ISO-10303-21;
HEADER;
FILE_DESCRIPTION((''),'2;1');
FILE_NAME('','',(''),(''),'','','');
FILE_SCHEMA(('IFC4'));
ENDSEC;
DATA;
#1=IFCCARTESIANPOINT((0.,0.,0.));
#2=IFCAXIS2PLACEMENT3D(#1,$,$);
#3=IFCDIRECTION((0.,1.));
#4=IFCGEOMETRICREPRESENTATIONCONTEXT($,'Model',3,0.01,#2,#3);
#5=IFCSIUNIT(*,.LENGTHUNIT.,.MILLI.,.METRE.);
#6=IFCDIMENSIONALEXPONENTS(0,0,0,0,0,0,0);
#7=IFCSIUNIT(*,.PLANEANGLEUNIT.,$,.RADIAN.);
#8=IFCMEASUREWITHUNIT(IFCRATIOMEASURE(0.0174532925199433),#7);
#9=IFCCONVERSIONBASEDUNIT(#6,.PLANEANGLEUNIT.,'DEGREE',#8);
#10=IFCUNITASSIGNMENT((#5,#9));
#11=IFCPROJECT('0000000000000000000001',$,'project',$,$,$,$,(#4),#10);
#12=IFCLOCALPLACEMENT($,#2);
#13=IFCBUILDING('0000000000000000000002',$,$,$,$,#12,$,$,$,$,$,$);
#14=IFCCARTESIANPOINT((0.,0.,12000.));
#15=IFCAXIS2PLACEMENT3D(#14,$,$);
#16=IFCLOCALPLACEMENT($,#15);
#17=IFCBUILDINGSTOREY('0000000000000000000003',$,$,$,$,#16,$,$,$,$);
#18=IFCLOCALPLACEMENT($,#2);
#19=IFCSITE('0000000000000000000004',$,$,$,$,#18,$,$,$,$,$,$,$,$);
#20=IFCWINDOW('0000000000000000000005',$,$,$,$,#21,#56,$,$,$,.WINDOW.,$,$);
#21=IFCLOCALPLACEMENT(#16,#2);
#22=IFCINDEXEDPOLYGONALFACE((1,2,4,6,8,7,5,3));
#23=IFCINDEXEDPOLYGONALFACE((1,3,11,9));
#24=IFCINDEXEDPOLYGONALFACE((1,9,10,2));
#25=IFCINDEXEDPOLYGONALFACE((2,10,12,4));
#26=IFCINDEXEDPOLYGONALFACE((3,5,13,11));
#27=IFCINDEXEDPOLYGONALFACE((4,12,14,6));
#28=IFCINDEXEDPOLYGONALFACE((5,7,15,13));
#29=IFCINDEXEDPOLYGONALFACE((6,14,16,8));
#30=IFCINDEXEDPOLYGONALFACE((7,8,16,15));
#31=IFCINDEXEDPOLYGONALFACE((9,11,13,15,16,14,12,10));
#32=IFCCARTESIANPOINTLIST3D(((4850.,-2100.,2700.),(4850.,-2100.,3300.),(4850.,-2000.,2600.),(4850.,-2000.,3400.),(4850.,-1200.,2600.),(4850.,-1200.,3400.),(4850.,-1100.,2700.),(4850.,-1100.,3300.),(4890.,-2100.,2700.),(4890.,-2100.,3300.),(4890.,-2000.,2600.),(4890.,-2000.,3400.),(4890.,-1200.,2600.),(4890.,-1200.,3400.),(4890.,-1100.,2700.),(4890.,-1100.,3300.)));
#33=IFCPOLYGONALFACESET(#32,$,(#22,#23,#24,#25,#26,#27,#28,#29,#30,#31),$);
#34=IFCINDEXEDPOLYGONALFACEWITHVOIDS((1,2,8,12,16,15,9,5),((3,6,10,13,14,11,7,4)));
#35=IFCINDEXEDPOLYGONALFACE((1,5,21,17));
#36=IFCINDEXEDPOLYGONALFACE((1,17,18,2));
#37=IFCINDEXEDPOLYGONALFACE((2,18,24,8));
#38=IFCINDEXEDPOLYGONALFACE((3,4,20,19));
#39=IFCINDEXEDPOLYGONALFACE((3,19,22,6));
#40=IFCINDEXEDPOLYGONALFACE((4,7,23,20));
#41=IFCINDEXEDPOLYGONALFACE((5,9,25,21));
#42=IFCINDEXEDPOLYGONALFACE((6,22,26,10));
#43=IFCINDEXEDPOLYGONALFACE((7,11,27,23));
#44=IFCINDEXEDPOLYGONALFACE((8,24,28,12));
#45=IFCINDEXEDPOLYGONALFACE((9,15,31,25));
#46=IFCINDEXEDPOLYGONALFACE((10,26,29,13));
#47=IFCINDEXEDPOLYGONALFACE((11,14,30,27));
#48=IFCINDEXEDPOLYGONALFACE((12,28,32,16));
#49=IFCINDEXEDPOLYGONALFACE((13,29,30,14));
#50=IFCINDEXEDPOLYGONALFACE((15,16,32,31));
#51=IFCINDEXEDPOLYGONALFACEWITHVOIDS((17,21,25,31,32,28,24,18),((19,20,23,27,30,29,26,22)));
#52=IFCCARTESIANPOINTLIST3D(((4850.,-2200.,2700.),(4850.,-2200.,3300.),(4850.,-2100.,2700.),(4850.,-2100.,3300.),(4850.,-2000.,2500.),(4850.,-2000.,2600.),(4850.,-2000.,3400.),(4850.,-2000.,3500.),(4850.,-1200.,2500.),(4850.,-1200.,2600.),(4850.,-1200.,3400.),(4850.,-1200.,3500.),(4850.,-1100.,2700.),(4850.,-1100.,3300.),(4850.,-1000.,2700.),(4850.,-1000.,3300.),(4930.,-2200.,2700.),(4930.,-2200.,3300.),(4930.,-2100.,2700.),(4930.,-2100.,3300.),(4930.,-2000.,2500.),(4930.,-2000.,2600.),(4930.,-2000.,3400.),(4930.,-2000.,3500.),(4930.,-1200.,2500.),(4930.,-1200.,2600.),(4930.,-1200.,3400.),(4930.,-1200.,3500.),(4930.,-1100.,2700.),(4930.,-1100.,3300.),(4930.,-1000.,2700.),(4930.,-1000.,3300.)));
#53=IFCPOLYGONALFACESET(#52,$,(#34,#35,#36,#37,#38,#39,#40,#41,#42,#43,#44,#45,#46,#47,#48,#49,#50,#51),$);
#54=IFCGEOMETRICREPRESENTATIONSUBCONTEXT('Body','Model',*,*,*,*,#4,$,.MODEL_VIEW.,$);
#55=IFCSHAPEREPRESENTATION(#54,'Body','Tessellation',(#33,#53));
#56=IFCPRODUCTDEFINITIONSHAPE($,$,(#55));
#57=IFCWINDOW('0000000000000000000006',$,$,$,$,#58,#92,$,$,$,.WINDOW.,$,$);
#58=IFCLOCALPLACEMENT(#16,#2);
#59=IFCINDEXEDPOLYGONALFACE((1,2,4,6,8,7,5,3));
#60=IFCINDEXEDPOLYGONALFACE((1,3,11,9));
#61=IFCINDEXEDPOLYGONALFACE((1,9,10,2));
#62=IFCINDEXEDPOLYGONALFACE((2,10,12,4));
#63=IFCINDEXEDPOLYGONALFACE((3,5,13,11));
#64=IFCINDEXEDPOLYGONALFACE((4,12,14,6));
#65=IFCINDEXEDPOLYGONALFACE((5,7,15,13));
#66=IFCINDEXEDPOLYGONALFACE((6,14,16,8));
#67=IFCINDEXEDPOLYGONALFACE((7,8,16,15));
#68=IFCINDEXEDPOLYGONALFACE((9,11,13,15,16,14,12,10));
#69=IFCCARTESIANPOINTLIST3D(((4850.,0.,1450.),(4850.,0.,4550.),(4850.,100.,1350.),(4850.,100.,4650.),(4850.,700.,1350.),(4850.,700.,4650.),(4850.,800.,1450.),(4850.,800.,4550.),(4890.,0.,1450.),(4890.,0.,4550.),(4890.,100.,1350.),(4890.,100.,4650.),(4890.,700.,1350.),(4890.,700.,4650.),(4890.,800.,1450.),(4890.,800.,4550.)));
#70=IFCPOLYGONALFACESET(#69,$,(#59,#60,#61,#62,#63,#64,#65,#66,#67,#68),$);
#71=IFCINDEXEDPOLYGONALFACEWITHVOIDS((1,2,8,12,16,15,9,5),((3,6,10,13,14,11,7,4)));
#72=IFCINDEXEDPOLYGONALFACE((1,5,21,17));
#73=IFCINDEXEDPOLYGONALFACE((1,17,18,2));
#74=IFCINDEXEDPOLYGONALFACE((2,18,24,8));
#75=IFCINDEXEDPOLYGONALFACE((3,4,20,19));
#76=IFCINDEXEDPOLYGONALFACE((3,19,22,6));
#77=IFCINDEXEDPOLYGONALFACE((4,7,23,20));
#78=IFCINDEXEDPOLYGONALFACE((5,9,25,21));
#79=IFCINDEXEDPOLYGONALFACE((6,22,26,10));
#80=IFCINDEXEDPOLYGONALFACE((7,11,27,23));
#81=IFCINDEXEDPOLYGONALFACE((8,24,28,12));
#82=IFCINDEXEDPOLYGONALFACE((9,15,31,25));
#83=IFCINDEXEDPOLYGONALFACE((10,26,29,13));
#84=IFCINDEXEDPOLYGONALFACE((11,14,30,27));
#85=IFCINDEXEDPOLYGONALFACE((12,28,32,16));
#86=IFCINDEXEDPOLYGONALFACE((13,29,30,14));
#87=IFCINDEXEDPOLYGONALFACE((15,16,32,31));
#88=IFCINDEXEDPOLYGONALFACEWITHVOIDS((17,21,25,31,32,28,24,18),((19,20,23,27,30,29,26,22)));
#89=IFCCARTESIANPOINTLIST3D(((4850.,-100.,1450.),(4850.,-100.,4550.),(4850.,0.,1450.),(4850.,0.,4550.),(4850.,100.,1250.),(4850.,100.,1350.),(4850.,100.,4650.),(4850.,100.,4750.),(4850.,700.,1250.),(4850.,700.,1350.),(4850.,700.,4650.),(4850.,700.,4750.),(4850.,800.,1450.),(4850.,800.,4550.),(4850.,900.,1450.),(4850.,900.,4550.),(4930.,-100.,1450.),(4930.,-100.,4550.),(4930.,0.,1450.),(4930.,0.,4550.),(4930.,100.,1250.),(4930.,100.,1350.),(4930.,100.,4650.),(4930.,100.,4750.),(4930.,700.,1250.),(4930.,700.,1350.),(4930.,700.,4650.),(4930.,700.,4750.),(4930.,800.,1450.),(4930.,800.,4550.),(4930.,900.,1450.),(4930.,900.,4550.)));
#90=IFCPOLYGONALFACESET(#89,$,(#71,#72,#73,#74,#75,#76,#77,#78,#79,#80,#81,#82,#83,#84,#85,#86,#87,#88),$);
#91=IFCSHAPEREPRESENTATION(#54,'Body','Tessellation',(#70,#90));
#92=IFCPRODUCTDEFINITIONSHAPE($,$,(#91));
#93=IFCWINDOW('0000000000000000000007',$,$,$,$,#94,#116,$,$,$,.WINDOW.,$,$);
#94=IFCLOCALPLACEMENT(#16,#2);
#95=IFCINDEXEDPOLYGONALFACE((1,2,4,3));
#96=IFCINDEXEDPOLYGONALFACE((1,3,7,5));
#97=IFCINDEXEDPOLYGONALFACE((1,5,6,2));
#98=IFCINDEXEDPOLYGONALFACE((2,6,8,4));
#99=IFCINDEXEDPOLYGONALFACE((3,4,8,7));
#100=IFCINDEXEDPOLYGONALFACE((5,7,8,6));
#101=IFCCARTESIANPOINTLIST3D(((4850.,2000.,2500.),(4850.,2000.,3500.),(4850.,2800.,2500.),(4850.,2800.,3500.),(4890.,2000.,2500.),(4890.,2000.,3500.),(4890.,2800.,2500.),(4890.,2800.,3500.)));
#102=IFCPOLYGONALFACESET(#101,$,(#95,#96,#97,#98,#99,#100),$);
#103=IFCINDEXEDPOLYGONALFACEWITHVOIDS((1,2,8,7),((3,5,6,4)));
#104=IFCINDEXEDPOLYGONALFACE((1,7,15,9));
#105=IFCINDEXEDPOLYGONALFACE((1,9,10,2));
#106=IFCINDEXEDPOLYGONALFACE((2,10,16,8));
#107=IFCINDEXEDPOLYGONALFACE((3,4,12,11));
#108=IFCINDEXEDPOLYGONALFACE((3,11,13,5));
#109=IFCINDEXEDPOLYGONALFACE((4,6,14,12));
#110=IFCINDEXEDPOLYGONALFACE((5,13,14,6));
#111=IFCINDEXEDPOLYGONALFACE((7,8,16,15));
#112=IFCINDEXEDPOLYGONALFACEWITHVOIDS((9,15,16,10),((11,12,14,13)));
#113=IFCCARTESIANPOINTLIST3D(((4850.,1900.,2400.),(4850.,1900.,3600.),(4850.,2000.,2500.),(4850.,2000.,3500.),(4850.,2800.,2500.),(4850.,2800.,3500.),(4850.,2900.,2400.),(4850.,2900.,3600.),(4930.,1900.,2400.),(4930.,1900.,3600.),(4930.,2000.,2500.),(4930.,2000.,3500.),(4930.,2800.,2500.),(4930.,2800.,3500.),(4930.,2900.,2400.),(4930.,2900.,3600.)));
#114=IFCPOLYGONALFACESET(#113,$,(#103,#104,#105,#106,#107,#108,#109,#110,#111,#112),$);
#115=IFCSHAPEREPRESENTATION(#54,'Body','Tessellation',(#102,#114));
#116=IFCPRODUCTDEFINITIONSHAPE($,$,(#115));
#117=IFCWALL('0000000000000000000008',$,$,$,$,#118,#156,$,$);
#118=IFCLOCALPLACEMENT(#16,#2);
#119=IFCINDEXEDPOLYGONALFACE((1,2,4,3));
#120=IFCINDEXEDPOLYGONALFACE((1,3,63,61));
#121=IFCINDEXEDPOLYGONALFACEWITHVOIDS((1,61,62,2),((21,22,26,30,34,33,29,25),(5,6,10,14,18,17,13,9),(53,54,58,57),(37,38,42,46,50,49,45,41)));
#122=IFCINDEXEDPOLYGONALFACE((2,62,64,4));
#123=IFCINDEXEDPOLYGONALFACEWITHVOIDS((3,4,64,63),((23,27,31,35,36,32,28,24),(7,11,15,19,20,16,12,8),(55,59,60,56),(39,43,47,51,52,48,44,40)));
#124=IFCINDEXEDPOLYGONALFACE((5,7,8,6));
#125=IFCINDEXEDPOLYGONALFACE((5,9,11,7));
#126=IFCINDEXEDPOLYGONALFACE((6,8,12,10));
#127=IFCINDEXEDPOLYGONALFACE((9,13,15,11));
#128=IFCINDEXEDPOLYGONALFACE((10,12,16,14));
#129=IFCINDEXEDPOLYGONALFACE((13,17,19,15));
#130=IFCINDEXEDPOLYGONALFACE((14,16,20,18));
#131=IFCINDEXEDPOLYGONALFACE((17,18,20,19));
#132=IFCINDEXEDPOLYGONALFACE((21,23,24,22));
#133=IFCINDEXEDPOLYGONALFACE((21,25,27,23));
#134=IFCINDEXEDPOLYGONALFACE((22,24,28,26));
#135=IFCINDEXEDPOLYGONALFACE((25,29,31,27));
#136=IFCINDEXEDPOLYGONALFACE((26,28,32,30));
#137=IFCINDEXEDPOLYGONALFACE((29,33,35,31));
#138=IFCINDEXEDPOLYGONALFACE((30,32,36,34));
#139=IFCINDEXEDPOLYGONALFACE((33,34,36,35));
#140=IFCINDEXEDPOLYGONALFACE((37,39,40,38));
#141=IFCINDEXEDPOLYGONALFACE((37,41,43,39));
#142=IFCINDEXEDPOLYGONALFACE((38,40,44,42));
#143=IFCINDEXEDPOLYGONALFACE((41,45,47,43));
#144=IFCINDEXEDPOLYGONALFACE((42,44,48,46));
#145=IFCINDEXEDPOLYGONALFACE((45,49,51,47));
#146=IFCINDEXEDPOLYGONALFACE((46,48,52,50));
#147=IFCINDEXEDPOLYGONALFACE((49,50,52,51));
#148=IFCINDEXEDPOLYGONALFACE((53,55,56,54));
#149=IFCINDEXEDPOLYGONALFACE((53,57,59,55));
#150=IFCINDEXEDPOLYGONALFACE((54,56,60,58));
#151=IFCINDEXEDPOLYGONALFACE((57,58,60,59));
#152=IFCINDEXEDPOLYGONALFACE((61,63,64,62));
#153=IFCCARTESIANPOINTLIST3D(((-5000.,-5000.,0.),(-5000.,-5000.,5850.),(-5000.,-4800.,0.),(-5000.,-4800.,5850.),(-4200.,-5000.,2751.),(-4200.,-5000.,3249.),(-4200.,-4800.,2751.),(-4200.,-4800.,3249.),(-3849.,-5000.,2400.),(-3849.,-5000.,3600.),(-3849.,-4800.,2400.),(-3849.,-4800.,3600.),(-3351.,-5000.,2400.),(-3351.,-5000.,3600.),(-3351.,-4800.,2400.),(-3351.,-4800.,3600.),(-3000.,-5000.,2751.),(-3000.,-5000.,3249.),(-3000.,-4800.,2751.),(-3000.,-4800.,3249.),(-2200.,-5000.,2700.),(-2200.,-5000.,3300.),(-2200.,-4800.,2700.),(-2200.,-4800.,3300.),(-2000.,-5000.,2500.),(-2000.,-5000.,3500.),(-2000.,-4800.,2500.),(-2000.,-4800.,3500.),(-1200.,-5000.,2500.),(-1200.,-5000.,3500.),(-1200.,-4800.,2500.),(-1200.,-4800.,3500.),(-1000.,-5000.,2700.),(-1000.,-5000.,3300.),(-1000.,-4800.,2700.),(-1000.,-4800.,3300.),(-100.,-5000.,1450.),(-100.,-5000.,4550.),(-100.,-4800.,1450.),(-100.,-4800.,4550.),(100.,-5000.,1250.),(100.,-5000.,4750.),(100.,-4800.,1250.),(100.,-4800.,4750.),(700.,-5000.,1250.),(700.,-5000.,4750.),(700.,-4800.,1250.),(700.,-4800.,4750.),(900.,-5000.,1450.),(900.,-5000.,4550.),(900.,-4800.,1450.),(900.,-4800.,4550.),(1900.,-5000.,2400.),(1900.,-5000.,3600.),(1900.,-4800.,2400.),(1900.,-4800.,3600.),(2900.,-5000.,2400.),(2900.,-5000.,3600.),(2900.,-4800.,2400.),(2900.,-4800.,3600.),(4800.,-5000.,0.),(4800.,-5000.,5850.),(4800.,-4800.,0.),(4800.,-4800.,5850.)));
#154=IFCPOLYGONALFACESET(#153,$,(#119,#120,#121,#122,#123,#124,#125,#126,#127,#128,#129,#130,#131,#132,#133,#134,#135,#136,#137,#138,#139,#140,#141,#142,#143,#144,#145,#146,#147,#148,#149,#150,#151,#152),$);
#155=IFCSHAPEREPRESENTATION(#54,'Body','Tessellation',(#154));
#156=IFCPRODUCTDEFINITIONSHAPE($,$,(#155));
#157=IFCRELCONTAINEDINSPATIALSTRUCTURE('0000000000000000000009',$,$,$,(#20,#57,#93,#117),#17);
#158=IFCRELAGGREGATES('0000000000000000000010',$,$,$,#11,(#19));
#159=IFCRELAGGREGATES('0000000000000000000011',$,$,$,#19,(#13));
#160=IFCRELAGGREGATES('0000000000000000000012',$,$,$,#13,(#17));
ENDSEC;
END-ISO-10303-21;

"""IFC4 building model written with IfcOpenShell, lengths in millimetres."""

from ifc_helpers import new_model, entity, si_unit, converted_unit, direction, frame, origin, origin_2d, place, context, subcontext, project, spatial, polyline, rectangle, outline, extrude, element, save


model = new_model("IFC4")

# Units and contexts
model_context = context("Model", 3, precision=0.01, world=origin(), true_north=direction((0.0, 1.0)))
body_context = subcontext(model_context, "Body", "Model", "MODEL_VIEW")
ifc_project = project(units=[si_unit("LENGTHUNIT", "METRE", prefix="MILLI"), converted_unit("PLANEANGLEUNIT", "DEGREE", entity("IfcRatioMeasure", 0.0174532925199433), si_unit("PLANEANGLEUNIT", "RADIAN"), dimensions=[0, 0, 0, 0, 0, 0, 0])], contexts=[model_context])

# Site, building, storey
site_placement = place(None, origin())
site = spatial("IfcSite", under=ifc_project, at=site_placement)
building_placement = place(None, origin())
building = spatial("IfcBuilding", under=site, at=building_placement)
storey_placement = place(None, frame((0.0, 0.0, 12000.0)))
storey = spatial("IfcBuildingStorey", under=building, at=storey_placement)

# Shared definitions
cartesian_point_1 = entity("IfcCartesianPoint", [-500.0, -300.0])
shared_polyline_1 = entity("IfcPolyline", [cartesian_point_1, entity("IfcCartesianPoint", [-500.0, 300.0]), entity("IfcCartesianPoint", [-400.0, 400.0]), entity("IfcCartesianPoint", [400.0, 400.0]), entity("IfcCartesianPoint", [500.0, 300.0]), entity("IfcCartesianPoint", [500.0, -300.0]), entity("IfcCartesianPoint", [400.0, -400.0]), entity("IfcCartesianPoint", [-400.0, -400.0]), cartesian_point_1])
cartesian_point_2 = entity("IfcCartesianPoint", [-400.0, -1550.0])
shared_polyline_2 = entity("IfcPolyline", [cartesian_point_2, entity("IfcCartesianPoint", [-400.0, 1550.0]), entity("IfcCartesianPoint", [-300.0, 1650.0]), entity("IfcCartesianPoint", [300.0, 1650.0]), entity("IfcCartesianPoint", [400.0, 1550.0]), entity("IfcCartesianPoint", [400.0, -1550.0]), entity("IfcCartesianPoint", [300.0, -1650.0]), entity("IfcCartesianPoint", [-300.0, -1650.0]), cartesian_point_2])
cartesian_point_3 = entity("IfcCartesianPoint", [-400.0, -500.0])
shared_polyline_3 = entity("IfcPolyline", [cartesian_point_3, entity("IfcCartesianPoint", [-400.0, 500.0]), entity("IfcCartesianPoint", [-400.0, 500.0]), entity("IfcCartesianPoint", [400.0, 500.0]), entity("IfcCartesianPoint", [400.0, 500.0]), entity("IfcCartesianPoint", [400.0, -500.0]), entity("IfcCartesianPoint", [400.0, -500.0]), entity("IfcCartesianPoint", [-400.0, -500.0]), cartesian_point_3])

# Shared definitions
wall_1_placement = place(storey_placement, frame((4900.0, -100.0, 0.0), z_axis=(0.0, 0.0, 1.0), x_axis=(0.0, 1.0, 0.0)))
window_1_placement = place(wall_1_placement, frame((-1500.0, 50.0, 3000.0)))
window_2_placement = place(wall_1_placement, frame((500.0, 50.0, 3000.0)))
window_3_placement = place(wall_1_placement, frame((2500.0, 50.0, 3000.0)))

# Windows
cartesian_point_4 = entity("IfcCartesianPoint", [-600.0, -300.0])
element("IfcWindow", 1, at=window_1_placement, inside=storey, PredefinedType="WINDOW", context=body_context, shape_type="SweptSolid", body=[
    entity("IfcExtrudedAreaSolid", entity("IfcArbitraryClosedProfileDef", "AREA", None, shared_polyline_1), entity("IfcAxis2Placement3D", entity("IfcCartesianPoint", [0.0, 0.0, 0.0]), entity("IfcDirection", [0.0, -1.0, 0.0]), entity("IfcDirection", [1.0, 0.0, 0.0])), entity("IfcDirection", [0.0, 0.0, 1.0]), 40.0),
    entity("IfcExtrudedAreaSolid", entity("IfcArbitraryProfileDefWithVoids", "AREA", None, entity("IfcPolyline", [cartesian_point_4, entity("IfcCartesianPoint", [-600.0, 300.0]), entity("IfcCartesianPoint", [-400.0, 500.0]), entity("IfcCartesianPoint", [400.0, 500.0]), entity("IfcCartesianPoint", [600.0, 300.0]), entity("IfcCartesianPoint", [600.0, -300.0]), entity("IfcCartesianPoint", [400.0, -500.0]), entity("IfcCartesianPoint", [-400.0, -500.0]), cartesian_point_4]), [shared_polyline_1]), entity("IfcAxis2Placement3D", entity("IfcCartesianPoint", [0.0, 0.0, 0.0]), entity("IfcDirection", [0.0, -1.0, 0.0]), entity("IfcDirection", [1.0, 0.0, 0.0])), entity("IfcDirection", [0.0, 0.0, 1.0]), 80.0),
])
cartesian_point_5 = entity("IfcCartesianPoint", [-500.0, -1550.0])
element("IfcWindow", 2, at=window_2_placement, inside=storey, PredefinedType="WINDOW", context=body_context, shape_type="SweptSolid", body=[
    entity("IfcExtrudedAreaSolid", entity("IfcArbitraryClosedProfileDef", "AREA", None, shared_polyline_2), entity("IfcAxis2Placement3D", entity("IfcCartesianPoint", [0.0, 0.0, 0.0]), entity("IfcDirection", [0.0, -1.0, 0.0]), entity("IfcDirection", [1.0, 0.0, 0.0])), entity("IfcDirection", [0.0, 0.0, 1.0]), 40.0),
    entity("IfcExtrudedAreaSolid", entity("IfcArbitraryProfileDefWithVoids", "AREA", None, entity("IfcPolyline", [cartesian_point_5, entity("IfcCartesianPoint", [-500.0, 1550.0]), entity("IfcCartesianPoint", [-300.0, 1750.0]), entity("IfcCartesianPoint", [300.0, 1750.0]), entity("IfcCartesianPoint", [500.0, 1550.0]), entity("IfcCartesianPoint", [500.0, -1550.0]), entity("IfcCartesianPoint", [300.0, -1750.0]), entity("IfcCartesianPoint", [-300.0, -1750.0]), cartesian_point_5]), [shared_polyline_2]), entity("IfcAxis2Placement3D", entity("IfcCartesianPoint", [0.0, 0.0, 0.0]), entity("IfcDirection", [0.0, -1.0, 0.0]), entity("IfcDirection", [1.0, 0.0, 0.0])), entity("IfcDirection", [0.0, 0.0, 1.0]), 80.0),
])
cartesian_point_6 = entity("IfcCartesianPoint", [-500.0, -600.0])
element("IfcWindow", 3, at=window_3_placement, inside=storey, PredefinedType="WINDOW", context=body_context, shape_type="SweptSolid", body=[
    entity("IfcExtrudedAreaSolid", entity("IfcArbitraryClosedProfileDef", "AREA", None, shared_polyline_3), entity("IfcAxis2Placement3D", entity("IfcCartesianPoint", [0.0, 0.0, 0.0]), entity("IfcDirection", [0.0, -1.0, 0.0]), entity("IfcDirection", [1.0, 0.0, 0.0])), entity("IfcDirection", [0.0, 0.0, 1.0]), 40.0),
    entity("IfcExtrudedAreaSolid", entity("IfcArbitraryProfileDefWithVoids", "AREA", None, entity("IfcPolyline", [cartesian_point_6, entity("IfcCartesianPoint", [-500.0, 600.0]), entity("IfcCartesianPoint", [-500.0, 600.0]), entity("IfcCartesianPoint", [500.0, 600.0]), entity("IfcCartesianPoint", [500.0, 600.0]), entity("IfcCartesianPoint", [500.0, -600.0]), entity("IfcCartesianPoint", [500.0, -600.0]), entity("IfcCartesianPoint", [-500.0, -600.0]), cartesian_point_6]), [shared_polyline_3]), entity("IfcAxis2Placement3D", entity("IfcCartesianPoint", [0.0, 0.0, 0.0]), entity("IfcDirection", [0.0, -1.0, 0.0]), entity("IfcDirection", [1.0, 0.0, 0.0])), entity("IfcDirection", [0.0, 0.0, 1.0]), 80.0),
])

# Wall, openings
wall_2_placement = place(storey_placement, frame((-100.0, -4900.0, 0.0), z_axis=(0.0, 0.0, 1.0), x_axis=(1.0, 0.0, 0.0)))
wall_2 = element("IfcWall", 4, at=wall_2_placement, inside=storey, context=body_context, shape_type="SweptSolid", body=[
    extrude(rectangle(XDim=9800.0, YDim=200.0, at=origin_2d()), origin(), (0.0, 0.0, 1.0), 5850.0),
])
window_4_placement = place(wall_2_placement, frame((-3500.0, 50.0, 3000.0)))
opening_1_placement = place(window_4_placement, frame((0.0, 50.0, 0.0)))
element("IfcOpeningElement", 5, at=opening_1_placement, cuts=wall_2, context=body_context, shape_type="SweptSolid", body=[
    extrude(outline(polyline([(-600.0, -249.0), (-600.0, 249.0), (-249.0, 600.0), (249.0, 600.0), (600.0, 249.0), (600.0, -249.0), (249.0, -600.0), (-249.0, -600.0), (-600.0, -249.0)])), frame((0.0, 0.0, 0.0), z_axis=(0.0, -1.0, 0.0), x_axis=(1.0, 0.0, 0.0)), (0.0, 0.0, 1.0), 200.0),
])
window_5_placement = place(wall_2_placement, frame((-1500.0, 50.0, 3000.0)))
opening_2_placement = place(window_5_placement, frame((0.0, 50.0, 0.0)))
element("IfcOpeningElement", 6, at=opening_2_placement, cuts=wall_2, context=body_context, shape_type="SweptSolid", body=[
    extrude(outline(polyline([(-600.0, -300.0), (-600.0, 300.0), (-400.0, 500.0), (400.0, 500.0), (600.0, 300.0), (600.0, -300.0), (400.0, -500.0), (-400.0, -500.0), (-600.0, -300.0)])), frame((0.0, 0.0, 0.0), z_axis=(0.0, -1.0, 0.0), x_axis=(1.0, 0.0, 0.0)), (0.0, 0.0, 1.0), 200.0),
])
window_6_placement = place(wall_2_placement, frame((500.0, 50.0, 3000.0)))
opening_3_placement = place(window_6_placement, frame((0.0, 50.0, 0.0)))
element("IfcOpeningElement", 7, at=opening_3_placement, cuts=wall_2, context=body_context, shape_type="SweptSolid", body=[
    extrude(outline(polyline([(-500.0, -1550.0), (-500.0, 1550.0), (-300.0, 1750.0), (300.0, 1750.0), (500.0, 1550.0), (500.0, -1550.0), (300.0, -1750.0), (-300.0, -1750.0), (-500.0, -1550.0)])), frame((0.0, 0.0, 0.0), z_axis=(0.0, -1.0, 0.0), x_axis=(1.0, 0.0, 0.0)), (0.0, 0.0, 1.0), 200.0),
])
window_7_placement = place(wall_2_placement, frame((2500.0, 50.0, 3000.0)))
opening_4_placement = place(window_7_placement, frame((0.0, 50.0, 0.0)))
element("IfcOpeningElement", 8, at=opening_4_placement, cuts=wall_2, context=body_context, shape_type="SweptSolid", body=[
    extrude(outline(polyline([(-500.0, -600.0), (-500.0, 600.0), (-500.0, 600.0), (500.0, 600.0), (500.0, 600.0), (500.0, -600.0), (500.0, -600.0), (-500.0, -600.0), (-500.0, -600.0)])), frame((0.0, 0.0, 0.0), z_axis=(0.0, -1.0, 0.0), x_axis=(1.0, 0.0, 0.0)), (0.0, 0.0, 1.0), 200.0),
])

save(model, "model.ifc")
